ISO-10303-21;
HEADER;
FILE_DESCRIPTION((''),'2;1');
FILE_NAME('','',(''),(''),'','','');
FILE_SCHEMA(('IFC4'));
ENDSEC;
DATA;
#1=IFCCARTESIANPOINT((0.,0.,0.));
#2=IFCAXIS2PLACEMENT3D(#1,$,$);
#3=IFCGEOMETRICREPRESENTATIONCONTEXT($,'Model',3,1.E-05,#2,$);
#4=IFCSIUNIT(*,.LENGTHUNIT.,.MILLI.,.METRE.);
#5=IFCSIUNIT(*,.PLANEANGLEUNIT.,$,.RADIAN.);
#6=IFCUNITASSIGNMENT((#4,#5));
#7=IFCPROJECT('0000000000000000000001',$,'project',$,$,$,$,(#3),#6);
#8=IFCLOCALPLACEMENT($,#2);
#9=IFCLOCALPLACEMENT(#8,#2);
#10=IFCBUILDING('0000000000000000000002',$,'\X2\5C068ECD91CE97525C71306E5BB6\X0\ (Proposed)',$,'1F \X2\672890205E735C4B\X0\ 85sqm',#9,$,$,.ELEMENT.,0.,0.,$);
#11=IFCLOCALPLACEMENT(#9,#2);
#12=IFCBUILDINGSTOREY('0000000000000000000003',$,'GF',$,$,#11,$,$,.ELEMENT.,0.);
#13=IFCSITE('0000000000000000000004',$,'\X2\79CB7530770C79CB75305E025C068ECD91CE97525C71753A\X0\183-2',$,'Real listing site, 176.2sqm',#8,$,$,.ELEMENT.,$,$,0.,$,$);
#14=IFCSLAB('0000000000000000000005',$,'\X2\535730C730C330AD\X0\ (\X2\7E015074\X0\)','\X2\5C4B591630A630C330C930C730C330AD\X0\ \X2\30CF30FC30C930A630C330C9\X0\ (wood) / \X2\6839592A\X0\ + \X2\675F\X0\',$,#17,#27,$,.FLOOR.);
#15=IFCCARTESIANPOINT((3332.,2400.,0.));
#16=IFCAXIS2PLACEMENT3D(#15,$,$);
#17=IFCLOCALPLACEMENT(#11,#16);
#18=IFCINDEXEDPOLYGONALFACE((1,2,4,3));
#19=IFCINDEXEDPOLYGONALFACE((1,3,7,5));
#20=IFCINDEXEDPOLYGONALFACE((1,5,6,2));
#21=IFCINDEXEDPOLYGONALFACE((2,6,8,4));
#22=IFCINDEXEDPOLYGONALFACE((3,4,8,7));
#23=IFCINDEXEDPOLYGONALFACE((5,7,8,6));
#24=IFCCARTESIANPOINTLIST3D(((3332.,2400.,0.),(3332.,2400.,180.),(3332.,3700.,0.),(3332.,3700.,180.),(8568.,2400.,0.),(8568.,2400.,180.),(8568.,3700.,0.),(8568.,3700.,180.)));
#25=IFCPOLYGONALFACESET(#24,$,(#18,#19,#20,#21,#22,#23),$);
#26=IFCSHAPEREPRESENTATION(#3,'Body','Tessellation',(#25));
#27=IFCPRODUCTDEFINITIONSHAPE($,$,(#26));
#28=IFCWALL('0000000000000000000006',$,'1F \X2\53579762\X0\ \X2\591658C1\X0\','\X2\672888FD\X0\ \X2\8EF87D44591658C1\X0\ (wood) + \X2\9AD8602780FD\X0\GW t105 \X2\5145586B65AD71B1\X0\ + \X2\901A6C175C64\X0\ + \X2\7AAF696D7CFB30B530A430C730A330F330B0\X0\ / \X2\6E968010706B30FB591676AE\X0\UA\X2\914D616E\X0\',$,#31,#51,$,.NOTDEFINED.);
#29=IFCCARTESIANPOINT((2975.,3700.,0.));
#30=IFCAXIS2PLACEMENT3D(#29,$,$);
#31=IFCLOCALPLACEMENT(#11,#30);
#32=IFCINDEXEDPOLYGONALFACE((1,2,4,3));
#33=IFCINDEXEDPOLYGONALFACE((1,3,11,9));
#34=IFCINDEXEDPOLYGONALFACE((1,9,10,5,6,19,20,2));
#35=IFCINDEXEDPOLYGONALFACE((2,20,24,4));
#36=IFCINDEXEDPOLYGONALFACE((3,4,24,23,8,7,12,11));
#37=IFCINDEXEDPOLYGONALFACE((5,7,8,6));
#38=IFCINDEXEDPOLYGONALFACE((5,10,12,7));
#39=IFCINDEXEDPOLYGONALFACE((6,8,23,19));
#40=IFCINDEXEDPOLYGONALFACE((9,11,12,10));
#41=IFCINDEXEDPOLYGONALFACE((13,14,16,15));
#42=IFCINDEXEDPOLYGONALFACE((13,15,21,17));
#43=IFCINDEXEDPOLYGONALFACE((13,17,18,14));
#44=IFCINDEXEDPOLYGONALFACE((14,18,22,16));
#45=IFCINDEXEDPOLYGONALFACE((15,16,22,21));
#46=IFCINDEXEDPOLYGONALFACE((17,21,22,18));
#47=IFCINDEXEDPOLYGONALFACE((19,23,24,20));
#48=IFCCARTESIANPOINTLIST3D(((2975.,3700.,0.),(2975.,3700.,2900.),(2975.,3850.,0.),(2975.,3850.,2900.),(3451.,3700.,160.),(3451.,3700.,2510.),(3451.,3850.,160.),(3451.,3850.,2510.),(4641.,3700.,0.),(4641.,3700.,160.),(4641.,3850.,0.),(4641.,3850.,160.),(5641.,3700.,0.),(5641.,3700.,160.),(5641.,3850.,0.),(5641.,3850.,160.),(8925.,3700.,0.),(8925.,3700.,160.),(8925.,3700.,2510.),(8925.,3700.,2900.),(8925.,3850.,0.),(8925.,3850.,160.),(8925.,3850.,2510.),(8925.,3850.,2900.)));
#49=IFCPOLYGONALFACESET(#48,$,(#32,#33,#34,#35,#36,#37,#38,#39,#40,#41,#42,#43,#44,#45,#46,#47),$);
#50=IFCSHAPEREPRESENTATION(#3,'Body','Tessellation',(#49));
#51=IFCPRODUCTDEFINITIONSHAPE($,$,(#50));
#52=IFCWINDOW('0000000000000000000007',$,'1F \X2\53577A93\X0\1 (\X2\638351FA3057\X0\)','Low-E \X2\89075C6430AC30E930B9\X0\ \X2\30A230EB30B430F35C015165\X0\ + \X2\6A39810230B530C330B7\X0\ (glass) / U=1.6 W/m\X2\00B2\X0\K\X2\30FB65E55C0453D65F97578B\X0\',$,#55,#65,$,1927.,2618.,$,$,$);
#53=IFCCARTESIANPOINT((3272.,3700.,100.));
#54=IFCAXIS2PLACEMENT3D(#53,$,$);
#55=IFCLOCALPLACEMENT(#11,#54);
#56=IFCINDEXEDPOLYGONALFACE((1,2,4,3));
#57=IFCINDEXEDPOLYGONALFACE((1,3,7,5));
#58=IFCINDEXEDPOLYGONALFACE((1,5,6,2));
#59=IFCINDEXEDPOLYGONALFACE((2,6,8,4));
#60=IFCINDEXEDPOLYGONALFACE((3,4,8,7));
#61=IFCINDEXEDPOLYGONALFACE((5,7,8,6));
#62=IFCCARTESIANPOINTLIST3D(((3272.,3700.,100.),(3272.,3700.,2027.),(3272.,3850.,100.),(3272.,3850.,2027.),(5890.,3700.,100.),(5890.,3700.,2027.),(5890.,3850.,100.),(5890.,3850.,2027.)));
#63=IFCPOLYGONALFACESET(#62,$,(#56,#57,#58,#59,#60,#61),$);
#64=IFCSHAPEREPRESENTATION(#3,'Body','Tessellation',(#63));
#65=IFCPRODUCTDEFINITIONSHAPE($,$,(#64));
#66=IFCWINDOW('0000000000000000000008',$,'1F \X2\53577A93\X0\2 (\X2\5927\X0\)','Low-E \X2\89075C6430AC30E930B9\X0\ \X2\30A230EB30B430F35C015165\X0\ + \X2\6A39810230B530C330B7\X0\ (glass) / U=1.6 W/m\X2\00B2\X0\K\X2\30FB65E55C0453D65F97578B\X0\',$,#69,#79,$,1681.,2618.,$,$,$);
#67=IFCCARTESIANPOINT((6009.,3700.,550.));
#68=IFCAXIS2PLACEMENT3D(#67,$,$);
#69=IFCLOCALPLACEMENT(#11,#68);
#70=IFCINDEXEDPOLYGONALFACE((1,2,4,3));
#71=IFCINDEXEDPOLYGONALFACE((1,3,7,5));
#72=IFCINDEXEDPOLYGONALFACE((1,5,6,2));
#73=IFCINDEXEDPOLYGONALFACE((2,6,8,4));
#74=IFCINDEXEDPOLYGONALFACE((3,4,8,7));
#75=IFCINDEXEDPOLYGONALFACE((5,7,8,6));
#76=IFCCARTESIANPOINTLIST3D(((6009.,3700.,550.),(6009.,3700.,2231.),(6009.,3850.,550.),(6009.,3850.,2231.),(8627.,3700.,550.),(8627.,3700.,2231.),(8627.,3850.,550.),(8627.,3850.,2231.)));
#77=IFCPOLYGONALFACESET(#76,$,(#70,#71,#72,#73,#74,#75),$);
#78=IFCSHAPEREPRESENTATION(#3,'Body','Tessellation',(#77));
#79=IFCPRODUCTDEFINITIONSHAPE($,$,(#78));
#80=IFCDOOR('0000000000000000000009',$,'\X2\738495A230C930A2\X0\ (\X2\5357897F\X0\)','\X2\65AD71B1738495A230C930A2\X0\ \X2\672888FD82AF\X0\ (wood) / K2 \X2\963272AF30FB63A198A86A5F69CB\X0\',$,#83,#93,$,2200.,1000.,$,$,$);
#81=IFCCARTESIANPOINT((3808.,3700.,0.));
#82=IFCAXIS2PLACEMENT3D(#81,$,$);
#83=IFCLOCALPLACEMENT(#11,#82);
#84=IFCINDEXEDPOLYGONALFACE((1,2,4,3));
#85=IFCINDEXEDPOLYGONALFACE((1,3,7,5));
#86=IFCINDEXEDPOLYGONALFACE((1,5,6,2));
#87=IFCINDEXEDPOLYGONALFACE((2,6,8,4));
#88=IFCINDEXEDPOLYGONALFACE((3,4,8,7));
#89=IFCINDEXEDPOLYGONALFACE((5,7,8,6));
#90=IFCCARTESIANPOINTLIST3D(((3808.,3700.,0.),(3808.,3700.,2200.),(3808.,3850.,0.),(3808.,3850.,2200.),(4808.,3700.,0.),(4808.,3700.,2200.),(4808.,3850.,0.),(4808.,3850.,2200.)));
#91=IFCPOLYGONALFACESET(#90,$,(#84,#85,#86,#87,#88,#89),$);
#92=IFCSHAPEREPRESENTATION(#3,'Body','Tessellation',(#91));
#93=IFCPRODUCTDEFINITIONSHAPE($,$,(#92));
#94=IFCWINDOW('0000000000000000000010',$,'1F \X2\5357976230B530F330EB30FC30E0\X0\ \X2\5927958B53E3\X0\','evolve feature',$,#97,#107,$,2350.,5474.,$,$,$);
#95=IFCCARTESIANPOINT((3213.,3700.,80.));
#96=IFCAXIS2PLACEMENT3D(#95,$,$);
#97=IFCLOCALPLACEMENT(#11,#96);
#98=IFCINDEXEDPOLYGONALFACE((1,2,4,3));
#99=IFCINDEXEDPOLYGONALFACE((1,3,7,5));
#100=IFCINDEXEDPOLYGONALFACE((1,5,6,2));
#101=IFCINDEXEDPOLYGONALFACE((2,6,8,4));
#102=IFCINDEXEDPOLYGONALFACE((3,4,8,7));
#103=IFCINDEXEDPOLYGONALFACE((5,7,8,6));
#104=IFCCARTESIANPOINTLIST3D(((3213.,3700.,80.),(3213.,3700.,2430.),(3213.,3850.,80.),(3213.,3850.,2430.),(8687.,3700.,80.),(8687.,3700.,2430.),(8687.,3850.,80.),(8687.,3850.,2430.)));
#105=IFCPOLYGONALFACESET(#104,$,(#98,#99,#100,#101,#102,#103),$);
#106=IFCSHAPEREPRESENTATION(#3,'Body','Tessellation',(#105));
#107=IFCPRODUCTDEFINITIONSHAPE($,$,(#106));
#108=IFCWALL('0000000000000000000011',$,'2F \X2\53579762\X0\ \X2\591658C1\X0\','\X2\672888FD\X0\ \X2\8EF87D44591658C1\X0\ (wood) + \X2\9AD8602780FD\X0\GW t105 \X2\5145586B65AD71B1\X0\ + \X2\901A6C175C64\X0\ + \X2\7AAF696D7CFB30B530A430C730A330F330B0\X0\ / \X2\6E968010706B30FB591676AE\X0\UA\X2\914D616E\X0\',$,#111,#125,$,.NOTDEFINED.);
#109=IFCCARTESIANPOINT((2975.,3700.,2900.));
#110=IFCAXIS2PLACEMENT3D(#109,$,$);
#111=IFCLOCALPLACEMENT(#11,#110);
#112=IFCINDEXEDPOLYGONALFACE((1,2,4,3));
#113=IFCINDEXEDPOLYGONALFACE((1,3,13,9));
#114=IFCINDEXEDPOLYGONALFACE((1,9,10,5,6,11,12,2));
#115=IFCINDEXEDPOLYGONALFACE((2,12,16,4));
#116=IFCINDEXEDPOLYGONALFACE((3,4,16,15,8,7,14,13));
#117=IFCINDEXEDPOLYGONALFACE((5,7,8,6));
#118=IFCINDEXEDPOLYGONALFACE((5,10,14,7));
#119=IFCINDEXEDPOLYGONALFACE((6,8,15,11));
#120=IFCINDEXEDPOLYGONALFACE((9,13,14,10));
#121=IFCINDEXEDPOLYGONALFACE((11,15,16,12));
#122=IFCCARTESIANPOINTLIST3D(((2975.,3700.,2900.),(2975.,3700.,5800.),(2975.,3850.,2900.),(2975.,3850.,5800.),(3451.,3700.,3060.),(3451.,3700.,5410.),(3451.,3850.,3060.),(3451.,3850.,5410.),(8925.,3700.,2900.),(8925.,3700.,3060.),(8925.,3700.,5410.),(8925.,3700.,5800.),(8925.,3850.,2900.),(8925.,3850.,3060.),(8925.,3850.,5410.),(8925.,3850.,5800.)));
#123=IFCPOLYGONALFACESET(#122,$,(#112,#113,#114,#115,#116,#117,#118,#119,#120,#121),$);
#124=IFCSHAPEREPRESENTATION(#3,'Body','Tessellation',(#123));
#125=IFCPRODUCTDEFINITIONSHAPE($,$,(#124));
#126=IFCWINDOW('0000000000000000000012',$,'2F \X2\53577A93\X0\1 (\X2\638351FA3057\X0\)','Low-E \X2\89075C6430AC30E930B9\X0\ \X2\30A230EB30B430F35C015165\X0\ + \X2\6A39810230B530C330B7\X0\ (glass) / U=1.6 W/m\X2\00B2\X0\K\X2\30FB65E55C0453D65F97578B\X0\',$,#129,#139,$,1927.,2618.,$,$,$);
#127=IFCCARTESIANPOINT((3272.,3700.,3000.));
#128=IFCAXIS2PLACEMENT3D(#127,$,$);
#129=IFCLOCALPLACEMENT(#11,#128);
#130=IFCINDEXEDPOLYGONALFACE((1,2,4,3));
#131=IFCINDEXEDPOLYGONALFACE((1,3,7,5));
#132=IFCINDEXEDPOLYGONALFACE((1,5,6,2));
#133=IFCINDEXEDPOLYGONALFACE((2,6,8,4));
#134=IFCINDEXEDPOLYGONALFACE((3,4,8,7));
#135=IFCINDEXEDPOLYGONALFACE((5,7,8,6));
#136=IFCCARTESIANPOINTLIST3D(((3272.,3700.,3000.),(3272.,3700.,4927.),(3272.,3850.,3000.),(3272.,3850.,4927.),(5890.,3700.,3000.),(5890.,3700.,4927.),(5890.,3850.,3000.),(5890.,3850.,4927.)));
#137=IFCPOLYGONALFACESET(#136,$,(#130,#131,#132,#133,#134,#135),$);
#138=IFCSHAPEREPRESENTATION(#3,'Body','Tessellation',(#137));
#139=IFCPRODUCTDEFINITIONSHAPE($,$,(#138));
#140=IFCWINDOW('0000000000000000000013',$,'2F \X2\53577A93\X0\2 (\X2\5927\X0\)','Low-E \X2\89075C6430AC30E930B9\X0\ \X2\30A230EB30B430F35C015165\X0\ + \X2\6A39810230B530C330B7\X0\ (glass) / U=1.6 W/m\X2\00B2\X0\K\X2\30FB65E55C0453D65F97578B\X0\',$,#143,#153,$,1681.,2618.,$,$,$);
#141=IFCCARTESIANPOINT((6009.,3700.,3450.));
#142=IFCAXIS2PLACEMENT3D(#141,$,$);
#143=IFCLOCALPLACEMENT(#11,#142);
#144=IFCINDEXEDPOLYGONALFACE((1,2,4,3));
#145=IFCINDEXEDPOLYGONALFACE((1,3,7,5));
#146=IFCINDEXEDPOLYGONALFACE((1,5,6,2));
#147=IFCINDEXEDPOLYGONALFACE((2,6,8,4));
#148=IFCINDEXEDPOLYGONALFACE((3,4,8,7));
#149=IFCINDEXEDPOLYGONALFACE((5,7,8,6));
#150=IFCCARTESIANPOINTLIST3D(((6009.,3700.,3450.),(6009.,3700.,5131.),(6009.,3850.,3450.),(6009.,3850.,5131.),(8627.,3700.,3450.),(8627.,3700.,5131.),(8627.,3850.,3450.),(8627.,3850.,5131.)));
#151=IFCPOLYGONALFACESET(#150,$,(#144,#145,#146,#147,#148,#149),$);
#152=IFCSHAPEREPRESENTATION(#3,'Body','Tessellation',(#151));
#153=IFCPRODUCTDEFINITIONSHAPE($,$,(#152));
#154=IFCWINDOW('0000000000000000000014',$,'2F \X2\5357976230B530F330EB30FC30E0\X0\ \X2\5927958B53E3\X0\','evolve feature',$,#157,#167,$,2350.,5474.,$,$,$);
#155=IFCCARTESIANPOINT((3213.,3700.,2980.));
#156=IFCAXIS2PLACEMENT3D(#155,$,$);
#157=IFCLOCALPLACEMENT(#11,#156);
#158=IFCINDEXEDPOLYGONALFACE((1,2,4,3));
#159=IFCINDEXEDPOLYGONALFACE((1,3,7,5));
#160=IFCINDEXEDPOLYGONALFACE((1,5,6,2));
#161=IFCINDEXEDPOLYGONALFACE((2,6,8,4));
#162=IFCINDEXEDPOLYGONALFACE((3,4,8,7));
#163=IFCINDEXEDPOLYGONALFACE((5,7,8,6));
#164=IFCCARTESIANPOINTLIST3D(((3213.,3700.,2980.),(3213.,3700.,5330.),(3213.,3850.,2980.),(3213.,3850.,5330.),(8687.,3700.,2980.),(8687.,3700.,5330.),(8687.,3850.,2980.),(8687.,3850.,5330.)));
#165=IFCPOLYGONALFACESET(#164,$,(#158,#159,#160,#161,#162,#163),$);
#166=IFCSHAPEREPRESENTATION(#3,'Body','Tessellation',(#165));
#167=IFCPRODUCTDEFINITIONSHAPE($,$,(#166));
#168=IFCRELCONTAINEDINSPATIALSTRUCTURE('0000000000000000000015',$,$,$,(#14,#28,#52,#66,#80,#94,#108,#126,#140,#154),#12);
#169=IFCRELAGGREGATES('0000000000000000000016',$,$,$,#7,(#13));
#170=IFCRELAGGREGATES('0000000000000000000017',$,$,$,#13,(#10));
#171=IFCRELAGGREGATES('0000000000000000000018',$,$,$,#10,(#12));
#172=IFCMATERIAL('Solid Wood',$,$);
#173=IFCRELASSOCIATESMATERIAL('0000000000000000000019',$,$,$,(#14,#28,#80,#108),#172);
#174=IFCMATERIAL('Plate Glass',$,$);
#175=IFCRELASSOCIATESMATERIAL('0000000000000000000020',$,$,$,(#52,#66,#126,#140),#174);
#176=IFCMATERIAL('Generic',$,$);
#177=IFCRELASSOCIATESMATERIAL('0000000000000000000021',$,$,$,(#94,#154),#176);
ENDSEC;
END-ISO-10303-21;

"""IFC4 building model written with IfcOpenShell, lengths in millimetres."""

from ifc_helpers import new_model, si_unit, frame, frame_2d, origin, place, context, project, spatial, rectangle, extrude, material, element, fill, save


model = new_model("IFC4")

# Units and contexts
model_context = context("Model", 3, precision=1e-05, world=origin())
ifc_project = project(units=[si_unit("LENGTHUNIT", "METRE", prefix="MILLI"), si_unit("PLANEANGLEUNIT", "RADIAN")], contexts=[model_context])

# Site, building, storey
site_placement = place(None, origin())
site = spatial("IfcSite", under=ifc_project, at=site_placement, Name="秋田県秋田市将軍野青山町183-2", ObjectType="Real listing site, 176.2sqm", CompositionType="ELEMENT", RefElevation=0.0)
building_placement = place(site_placement, origin())
building = spatial("IfcBuilding", under=site, at=building_placement, Name="将軍野青山の家 (Proposed)", ObjectType="1F 木造平屋 85sqm", CompositionType="ELEMENT", ElevationOfRefHeight=0.0, ElevationOfTerrain=0.0)
storey_placement = place(building_placement, origin())
storey = spatial("IfcBuildingStorey", under=building, at=storey_placement, Name="GF", CompositionType="ELEMENT", Elevation=0.0)

# Slab
ifc_material_1 = material(Name="Solid Wood")
slab_1_placement = place(storey_placement, frame((3332.0, 2400.0, 0.0)))
element("IfcSlab", 1, at=slab_1_placement, inside=storey, material=ifc_material_1, Name="南デッキ (縁側)", Description="屋外ウッドデッキ ハードウッド (wood) / 根太 + 束", PredefinedType="FLOOR", context=model_context, shape_type="SweptSolid", body=[
    extrude(rectangle(XDim=5236.0, YDim=1300.0, at=frame_2d((2618.0, 650.0))), frame((3332.0, 2400.0, 0.0)), (0.0, 0.0, 1.0), 180.0),
])
ifc_material_2 = material(Name="Generic")

# Wall, openings, windows, door
wall_1_placement = place(storey_placement, frame((2975.0, 3700.0, 0.0)))
wall_1 = element("IfcWall", 2, at=wall_1_placement, inside=storey, material=ifc_material_1, Name="1F 南面 外壁", Description="木製 軸組外壁 (wood) + 高性能GW t105 充填断熱 + 通気層 + 窯業系サイディング / 準耐火・外皮UA配慮", PredefinedType="NOTDEFINED", context=model_context, shape_type="SweptSolid", body=[
    extrude(rectangle(XDim=5950.0, YDim=150.0, at=frame_2d((2975.0, 75.0))), frame((2975.0, 3700.0, 0.0)), (0.0, 0.0, 1.0), 2900.0),
])
opening_1_placement = place(storey_placement, frame((3272.0, 3700.0, 100.0)))
opening_1 = element("IfcOpeningElement", 3, at=opening_1_placement, cuts=wall_1, PredefinedType="NOTDEFINED", context=model_context, shape_type="SweptSolid", body=[
    extrude(rectangle(XDim=2618.0, YDim=150.0, at=frame_2d((1309.0, 75.0))), frame((3272.0, 3700.0, 100.0)), (0.0, 0.0, 1.0), 1927.0),
])
opening_2_placement = place(storey_placement, frame((6009.0, 3700.0, 550.0)))
opening_2 = element("IfcOpeningElement", 4, at=opening_2_placement, cuts=wall_1, PredefinedType="NOTDEFINED", context=model_context, shape_type="SweptSolid", body=[
    extrude(rectangle(XDim=2618.0, YDim=150.0, at=frame_2d((1309.0, 75.0))), frame((6009.0, 3700.0, 550.0)), (0.0, 0.0, 1.0), 1681.0),
])
opening_3_placement = place(storey_placement, frame((3808.0, 3700.0, 0.0)))
opening_3 = element("IfcOpeningElement", 5, at=opening_3_placement, cuts=wall_1, PredefinedType="NOTDEFINED", context=model_context, shape_type="SweptSolid", body=[
    extrude(rectangle(XDim=1000.0, YDim=150.0, at=frame_2d((500.0, 75.0))), frame((3808.0, 3700.0, 0.0)), (0.0, 0.0, 1.0), 2200.0),
])
opening_4_placement = place(storey_placement, frame((3213.0, 3700.0, 80.0)))
opening_4 = element("IfcOpeningElement", 6, at=opening_4_placement, cuts=wall_1, PredefinedType="NOTDEFINED", context=model_context, shape_type="SweptSolid", body=[
    extrude(rectangle(XDim=5474.0, YDim=150.0, at=frame_2d((2737.0, 75.0))), frame((3213.0, 3700.0, 80.0)), (0.0, 0.0, 1.0), 2350.0),
])
ifc_material_3 = material(Name="Plate Glass")
window_1_placement = place(storey_placement, frame((3272.0, 3700.0, 100.0)))
window_1 = element("IfcWindow", 7, at=window_1_placement, inside=storey, material=ifc_material_3, Name="1F 南窓1 (掃出し)", Description="Low-E 複層ガラス アルゴン封入 + 樹脂サッシ (glass) / U=1.6 W/m²K・日射取得型", OverallHeight=1927.0, OverallWidth=2618.0, context=model_context, shape_type="SweptSolid", body=[
    extrude(rectangle(XDim=2618.0, YDim=150.0, at=frame_2d((1309.0, 75.0))), frame((3272.0, 3700.0, 100.0)), (0.0, 0.0, 1.0), 1927.0),
])
fill(opening_1, window_1)
window_2_placement = place(storey_placement, frame((6009.0, 3700.0, 550.0)))
window_2 = element("IfcWindow", 8, at=window_2_placement, inside=storey, material=ifc_material_3, Name="1F 南窓2 (大)", Description="Low-E 複層ガラス アルゴン封入 + 樹脂サッシ (glass) / U=1.6 W/m²K・日射取得型", OverallHeight=1681.0, OverallWidth=2618.0, context=model_context, shape_type="SweptSolid", body=[
    extrude(rectangle(XDim=2618.0, YDim=150.0, at=frame_2d((1309.0, 75.0))), frame((6009.0, 3700.0, 550.0)), (0.0, 0.0, 1.0), 1681.0),
])
fill(opening_2, window_2)
door_placement = place(storey_placement, frame((3808.0, 3700.0, 0.0)))
door = element("IfcDoor", 9, at=door_placement, inside=storey, material=ifc_material_1, Name="玄関ドア (南西)", Description="断熱玄関ドア 木製芯 (wood) / K2 防犯・採風機構", OverallHeight=2200.0, OverallWidth=1000.0, context=model_context, shape_type="SweptSolid", body=[
    extrude(rectangle(XDim=1000.0, YDim=150.0, at=frame_2d((500.0, 75.0))), frame((3808.0, 3700.0, 0.0)), (0.0, 0.0, 1.0), 2200.0),
])
fill(opening_3, door)
window_3_placement = place(storey_placement, frame((3213.0, 3700.0, 80.0)))
window_3 = element("IfcWindow", 10, at=window_3_placement, inside=storey, material=ifc_material_2, Name="1F 南面サンルーム 大開口", Description="evolve feature", OverallHeight=2350.0, OverallWidth=5474.0, context=model_context, shape_type="SweptSolid", body=[
    extrude(rectangle(XDim=5474.0, YDim=150.0, at=frame_2d((2737.0, 75.0))), frame((3213.0, 3700.0, 80.0)), (0.0, 0.0, 1.0), 2350.0),
])
fill(opening_4, window_3)

# Wall, openings, windows
wall_2_placement = place(storey_placement, frame((2975.0, 3700.0, 2900.0)))
wall_2 = element("IfcWall", 11, at=wall_2_placement, inside=storey, material=ifc_material_1, Name="2F 南面 外壁", Description="木製 軸組外壁 (wood) + 高性能GW t105 充填断熱 + 通気層 + 窯業系サイディング / 準耐火・外皮UA配慮", PredefinedType="NOTDEFINED", context=model_context, shape_type="SweptSolid", body=[
    extrude(rectangle(XDim=5950.0, YDim=150.0, at=frame_2d((2975.0, 75.0))), frame((2975.0, 3700.0, 2900.0)), (0.0, 0.0, 1.0), 2900.0),
])
opening_5_placement = place(storey_placement, frame((3272.0, 3700.0, 3000.0)))
opening_5 = element("IfcOpeningElement", 12, at=opening_5_placement, cuts=wall_2, PredefinedType="NOTDEFINED", context=model_context, shape_type="SweptSolid", body=[
    extrude(rectangle(XDim=2618.0, YDim=150.0, at=frame_2d((1309.0, 75.0))), frame((3272.0, 3700.0, 3000.0)), (0.0, 0.0, 1.0), 1927.0),
])
opening_6_placement = place(storey_placement, frame((6009.0, 3700.0, 3450.0)))
opening_6 = element("IfcOpeningElement", 13, at=opening_6_placement, cuts=wall_2, PredefinedType="NOTDEFINED", context=model_context, shape_type="SweptSolid", body=[
    extrude(rectangle(XDim=2618.0, YDim=150.0, at=frame_2d((1309.0, 75.0))), frame((6009.0, 3700.0, 3450.0)), (0.0, 0.0, 1.0), 1681.0),
])
opening_7_placement = place(storey_placement, frame((3213.0, 3700.0, 2980.0)))
opening_7 = element("IfcOpeningElement", 14, at=opening_7_placement, cuts=wall_2, PredefinedType="NOTDEFINED", context=model_context, shape_type="SweptSolid", body=[
    extrude(rectangle(XDim=5474.0, YDim=150.0, at=frame_2d((2737.0, 75.0))), frame((3213.0, 3700.0, 2980.0)), (0.0, 0.0, 1.0), 2350.0),
])
window_4_placement = place(storey_placement, frame((3272.0, 3700.0, 3000.0)))
window_4 = element("IfcWindow", 15, at=window_4_placement, inside=storey, material=ifc_material_3, Name="2F 南窓1 (掃出し)", Description="Low-E 複層ガラス アルゴン封入 + 樹脂サッシ (glass) / U=1.6 W/m²K・日射取得型", OverallHeight=1927.0, OverallWidth=2618.0, context=model_context, shape_type="SweptSolid", body=[
    extrude(rectangle(XDim=2618.0, YDim=150.0, at=frame_2d((1309.0, 75.0))), frame((3272.0, 3700.0, 3000.0)), (0.0, 0.0, 1.0), 1927.0),
])
fill(opening_5, window_4)
window_5_placement = place(storey_placement, frame((6009.0, 3700.0, 3450.0)))
window_5 = element("IfcWindow", 16, at=window_5_placement, inside=storey, material=ifc_material_3, Name="2F 南窓2 (大)", Description="Low-E 複層ガラス アルゴン封入 + 樹脂サッシ (glass) / U=1.6 W/m²K・日射取得型", OverallHeight=1681.0, OverallWidth=2618.0, context=model_context, shape_type="SweptSolid", body=[
    extrude(rectangle(XDim=2618.0, YDim=150.0, at=frame_2d((1309.0, 75.0))), frame((6009.0, 3700.0, 3450.0)), (0.0, 0.0, 1.0), 1681.0),
])
fill(opening_6, window_5)
window_6_placement = place(storey_placement, frame((3213.0, 3700.0, 2980.0)))
window_6 = element("IfcWindow", 17, at=window_6_placement, inside=storey, material=ifc_material_2, Name="2F 南面サンルーム 大開口", Description="evolve feature", OverallHeight=2350.0, OverallWidth=5474.0, context=model_context, shape_type="SweptSolid", body=[
    extrude(rectangle(XDim=5474.0, YDim=150.0, at=frame_2d((2737.0, 75.0))), frame((3213.0, 3700.0, 2980.0)), (0.0, 0.0, 1.0), 2350.0),
])
fill(opening_7, window_6)

save(model, "model.ifc")
